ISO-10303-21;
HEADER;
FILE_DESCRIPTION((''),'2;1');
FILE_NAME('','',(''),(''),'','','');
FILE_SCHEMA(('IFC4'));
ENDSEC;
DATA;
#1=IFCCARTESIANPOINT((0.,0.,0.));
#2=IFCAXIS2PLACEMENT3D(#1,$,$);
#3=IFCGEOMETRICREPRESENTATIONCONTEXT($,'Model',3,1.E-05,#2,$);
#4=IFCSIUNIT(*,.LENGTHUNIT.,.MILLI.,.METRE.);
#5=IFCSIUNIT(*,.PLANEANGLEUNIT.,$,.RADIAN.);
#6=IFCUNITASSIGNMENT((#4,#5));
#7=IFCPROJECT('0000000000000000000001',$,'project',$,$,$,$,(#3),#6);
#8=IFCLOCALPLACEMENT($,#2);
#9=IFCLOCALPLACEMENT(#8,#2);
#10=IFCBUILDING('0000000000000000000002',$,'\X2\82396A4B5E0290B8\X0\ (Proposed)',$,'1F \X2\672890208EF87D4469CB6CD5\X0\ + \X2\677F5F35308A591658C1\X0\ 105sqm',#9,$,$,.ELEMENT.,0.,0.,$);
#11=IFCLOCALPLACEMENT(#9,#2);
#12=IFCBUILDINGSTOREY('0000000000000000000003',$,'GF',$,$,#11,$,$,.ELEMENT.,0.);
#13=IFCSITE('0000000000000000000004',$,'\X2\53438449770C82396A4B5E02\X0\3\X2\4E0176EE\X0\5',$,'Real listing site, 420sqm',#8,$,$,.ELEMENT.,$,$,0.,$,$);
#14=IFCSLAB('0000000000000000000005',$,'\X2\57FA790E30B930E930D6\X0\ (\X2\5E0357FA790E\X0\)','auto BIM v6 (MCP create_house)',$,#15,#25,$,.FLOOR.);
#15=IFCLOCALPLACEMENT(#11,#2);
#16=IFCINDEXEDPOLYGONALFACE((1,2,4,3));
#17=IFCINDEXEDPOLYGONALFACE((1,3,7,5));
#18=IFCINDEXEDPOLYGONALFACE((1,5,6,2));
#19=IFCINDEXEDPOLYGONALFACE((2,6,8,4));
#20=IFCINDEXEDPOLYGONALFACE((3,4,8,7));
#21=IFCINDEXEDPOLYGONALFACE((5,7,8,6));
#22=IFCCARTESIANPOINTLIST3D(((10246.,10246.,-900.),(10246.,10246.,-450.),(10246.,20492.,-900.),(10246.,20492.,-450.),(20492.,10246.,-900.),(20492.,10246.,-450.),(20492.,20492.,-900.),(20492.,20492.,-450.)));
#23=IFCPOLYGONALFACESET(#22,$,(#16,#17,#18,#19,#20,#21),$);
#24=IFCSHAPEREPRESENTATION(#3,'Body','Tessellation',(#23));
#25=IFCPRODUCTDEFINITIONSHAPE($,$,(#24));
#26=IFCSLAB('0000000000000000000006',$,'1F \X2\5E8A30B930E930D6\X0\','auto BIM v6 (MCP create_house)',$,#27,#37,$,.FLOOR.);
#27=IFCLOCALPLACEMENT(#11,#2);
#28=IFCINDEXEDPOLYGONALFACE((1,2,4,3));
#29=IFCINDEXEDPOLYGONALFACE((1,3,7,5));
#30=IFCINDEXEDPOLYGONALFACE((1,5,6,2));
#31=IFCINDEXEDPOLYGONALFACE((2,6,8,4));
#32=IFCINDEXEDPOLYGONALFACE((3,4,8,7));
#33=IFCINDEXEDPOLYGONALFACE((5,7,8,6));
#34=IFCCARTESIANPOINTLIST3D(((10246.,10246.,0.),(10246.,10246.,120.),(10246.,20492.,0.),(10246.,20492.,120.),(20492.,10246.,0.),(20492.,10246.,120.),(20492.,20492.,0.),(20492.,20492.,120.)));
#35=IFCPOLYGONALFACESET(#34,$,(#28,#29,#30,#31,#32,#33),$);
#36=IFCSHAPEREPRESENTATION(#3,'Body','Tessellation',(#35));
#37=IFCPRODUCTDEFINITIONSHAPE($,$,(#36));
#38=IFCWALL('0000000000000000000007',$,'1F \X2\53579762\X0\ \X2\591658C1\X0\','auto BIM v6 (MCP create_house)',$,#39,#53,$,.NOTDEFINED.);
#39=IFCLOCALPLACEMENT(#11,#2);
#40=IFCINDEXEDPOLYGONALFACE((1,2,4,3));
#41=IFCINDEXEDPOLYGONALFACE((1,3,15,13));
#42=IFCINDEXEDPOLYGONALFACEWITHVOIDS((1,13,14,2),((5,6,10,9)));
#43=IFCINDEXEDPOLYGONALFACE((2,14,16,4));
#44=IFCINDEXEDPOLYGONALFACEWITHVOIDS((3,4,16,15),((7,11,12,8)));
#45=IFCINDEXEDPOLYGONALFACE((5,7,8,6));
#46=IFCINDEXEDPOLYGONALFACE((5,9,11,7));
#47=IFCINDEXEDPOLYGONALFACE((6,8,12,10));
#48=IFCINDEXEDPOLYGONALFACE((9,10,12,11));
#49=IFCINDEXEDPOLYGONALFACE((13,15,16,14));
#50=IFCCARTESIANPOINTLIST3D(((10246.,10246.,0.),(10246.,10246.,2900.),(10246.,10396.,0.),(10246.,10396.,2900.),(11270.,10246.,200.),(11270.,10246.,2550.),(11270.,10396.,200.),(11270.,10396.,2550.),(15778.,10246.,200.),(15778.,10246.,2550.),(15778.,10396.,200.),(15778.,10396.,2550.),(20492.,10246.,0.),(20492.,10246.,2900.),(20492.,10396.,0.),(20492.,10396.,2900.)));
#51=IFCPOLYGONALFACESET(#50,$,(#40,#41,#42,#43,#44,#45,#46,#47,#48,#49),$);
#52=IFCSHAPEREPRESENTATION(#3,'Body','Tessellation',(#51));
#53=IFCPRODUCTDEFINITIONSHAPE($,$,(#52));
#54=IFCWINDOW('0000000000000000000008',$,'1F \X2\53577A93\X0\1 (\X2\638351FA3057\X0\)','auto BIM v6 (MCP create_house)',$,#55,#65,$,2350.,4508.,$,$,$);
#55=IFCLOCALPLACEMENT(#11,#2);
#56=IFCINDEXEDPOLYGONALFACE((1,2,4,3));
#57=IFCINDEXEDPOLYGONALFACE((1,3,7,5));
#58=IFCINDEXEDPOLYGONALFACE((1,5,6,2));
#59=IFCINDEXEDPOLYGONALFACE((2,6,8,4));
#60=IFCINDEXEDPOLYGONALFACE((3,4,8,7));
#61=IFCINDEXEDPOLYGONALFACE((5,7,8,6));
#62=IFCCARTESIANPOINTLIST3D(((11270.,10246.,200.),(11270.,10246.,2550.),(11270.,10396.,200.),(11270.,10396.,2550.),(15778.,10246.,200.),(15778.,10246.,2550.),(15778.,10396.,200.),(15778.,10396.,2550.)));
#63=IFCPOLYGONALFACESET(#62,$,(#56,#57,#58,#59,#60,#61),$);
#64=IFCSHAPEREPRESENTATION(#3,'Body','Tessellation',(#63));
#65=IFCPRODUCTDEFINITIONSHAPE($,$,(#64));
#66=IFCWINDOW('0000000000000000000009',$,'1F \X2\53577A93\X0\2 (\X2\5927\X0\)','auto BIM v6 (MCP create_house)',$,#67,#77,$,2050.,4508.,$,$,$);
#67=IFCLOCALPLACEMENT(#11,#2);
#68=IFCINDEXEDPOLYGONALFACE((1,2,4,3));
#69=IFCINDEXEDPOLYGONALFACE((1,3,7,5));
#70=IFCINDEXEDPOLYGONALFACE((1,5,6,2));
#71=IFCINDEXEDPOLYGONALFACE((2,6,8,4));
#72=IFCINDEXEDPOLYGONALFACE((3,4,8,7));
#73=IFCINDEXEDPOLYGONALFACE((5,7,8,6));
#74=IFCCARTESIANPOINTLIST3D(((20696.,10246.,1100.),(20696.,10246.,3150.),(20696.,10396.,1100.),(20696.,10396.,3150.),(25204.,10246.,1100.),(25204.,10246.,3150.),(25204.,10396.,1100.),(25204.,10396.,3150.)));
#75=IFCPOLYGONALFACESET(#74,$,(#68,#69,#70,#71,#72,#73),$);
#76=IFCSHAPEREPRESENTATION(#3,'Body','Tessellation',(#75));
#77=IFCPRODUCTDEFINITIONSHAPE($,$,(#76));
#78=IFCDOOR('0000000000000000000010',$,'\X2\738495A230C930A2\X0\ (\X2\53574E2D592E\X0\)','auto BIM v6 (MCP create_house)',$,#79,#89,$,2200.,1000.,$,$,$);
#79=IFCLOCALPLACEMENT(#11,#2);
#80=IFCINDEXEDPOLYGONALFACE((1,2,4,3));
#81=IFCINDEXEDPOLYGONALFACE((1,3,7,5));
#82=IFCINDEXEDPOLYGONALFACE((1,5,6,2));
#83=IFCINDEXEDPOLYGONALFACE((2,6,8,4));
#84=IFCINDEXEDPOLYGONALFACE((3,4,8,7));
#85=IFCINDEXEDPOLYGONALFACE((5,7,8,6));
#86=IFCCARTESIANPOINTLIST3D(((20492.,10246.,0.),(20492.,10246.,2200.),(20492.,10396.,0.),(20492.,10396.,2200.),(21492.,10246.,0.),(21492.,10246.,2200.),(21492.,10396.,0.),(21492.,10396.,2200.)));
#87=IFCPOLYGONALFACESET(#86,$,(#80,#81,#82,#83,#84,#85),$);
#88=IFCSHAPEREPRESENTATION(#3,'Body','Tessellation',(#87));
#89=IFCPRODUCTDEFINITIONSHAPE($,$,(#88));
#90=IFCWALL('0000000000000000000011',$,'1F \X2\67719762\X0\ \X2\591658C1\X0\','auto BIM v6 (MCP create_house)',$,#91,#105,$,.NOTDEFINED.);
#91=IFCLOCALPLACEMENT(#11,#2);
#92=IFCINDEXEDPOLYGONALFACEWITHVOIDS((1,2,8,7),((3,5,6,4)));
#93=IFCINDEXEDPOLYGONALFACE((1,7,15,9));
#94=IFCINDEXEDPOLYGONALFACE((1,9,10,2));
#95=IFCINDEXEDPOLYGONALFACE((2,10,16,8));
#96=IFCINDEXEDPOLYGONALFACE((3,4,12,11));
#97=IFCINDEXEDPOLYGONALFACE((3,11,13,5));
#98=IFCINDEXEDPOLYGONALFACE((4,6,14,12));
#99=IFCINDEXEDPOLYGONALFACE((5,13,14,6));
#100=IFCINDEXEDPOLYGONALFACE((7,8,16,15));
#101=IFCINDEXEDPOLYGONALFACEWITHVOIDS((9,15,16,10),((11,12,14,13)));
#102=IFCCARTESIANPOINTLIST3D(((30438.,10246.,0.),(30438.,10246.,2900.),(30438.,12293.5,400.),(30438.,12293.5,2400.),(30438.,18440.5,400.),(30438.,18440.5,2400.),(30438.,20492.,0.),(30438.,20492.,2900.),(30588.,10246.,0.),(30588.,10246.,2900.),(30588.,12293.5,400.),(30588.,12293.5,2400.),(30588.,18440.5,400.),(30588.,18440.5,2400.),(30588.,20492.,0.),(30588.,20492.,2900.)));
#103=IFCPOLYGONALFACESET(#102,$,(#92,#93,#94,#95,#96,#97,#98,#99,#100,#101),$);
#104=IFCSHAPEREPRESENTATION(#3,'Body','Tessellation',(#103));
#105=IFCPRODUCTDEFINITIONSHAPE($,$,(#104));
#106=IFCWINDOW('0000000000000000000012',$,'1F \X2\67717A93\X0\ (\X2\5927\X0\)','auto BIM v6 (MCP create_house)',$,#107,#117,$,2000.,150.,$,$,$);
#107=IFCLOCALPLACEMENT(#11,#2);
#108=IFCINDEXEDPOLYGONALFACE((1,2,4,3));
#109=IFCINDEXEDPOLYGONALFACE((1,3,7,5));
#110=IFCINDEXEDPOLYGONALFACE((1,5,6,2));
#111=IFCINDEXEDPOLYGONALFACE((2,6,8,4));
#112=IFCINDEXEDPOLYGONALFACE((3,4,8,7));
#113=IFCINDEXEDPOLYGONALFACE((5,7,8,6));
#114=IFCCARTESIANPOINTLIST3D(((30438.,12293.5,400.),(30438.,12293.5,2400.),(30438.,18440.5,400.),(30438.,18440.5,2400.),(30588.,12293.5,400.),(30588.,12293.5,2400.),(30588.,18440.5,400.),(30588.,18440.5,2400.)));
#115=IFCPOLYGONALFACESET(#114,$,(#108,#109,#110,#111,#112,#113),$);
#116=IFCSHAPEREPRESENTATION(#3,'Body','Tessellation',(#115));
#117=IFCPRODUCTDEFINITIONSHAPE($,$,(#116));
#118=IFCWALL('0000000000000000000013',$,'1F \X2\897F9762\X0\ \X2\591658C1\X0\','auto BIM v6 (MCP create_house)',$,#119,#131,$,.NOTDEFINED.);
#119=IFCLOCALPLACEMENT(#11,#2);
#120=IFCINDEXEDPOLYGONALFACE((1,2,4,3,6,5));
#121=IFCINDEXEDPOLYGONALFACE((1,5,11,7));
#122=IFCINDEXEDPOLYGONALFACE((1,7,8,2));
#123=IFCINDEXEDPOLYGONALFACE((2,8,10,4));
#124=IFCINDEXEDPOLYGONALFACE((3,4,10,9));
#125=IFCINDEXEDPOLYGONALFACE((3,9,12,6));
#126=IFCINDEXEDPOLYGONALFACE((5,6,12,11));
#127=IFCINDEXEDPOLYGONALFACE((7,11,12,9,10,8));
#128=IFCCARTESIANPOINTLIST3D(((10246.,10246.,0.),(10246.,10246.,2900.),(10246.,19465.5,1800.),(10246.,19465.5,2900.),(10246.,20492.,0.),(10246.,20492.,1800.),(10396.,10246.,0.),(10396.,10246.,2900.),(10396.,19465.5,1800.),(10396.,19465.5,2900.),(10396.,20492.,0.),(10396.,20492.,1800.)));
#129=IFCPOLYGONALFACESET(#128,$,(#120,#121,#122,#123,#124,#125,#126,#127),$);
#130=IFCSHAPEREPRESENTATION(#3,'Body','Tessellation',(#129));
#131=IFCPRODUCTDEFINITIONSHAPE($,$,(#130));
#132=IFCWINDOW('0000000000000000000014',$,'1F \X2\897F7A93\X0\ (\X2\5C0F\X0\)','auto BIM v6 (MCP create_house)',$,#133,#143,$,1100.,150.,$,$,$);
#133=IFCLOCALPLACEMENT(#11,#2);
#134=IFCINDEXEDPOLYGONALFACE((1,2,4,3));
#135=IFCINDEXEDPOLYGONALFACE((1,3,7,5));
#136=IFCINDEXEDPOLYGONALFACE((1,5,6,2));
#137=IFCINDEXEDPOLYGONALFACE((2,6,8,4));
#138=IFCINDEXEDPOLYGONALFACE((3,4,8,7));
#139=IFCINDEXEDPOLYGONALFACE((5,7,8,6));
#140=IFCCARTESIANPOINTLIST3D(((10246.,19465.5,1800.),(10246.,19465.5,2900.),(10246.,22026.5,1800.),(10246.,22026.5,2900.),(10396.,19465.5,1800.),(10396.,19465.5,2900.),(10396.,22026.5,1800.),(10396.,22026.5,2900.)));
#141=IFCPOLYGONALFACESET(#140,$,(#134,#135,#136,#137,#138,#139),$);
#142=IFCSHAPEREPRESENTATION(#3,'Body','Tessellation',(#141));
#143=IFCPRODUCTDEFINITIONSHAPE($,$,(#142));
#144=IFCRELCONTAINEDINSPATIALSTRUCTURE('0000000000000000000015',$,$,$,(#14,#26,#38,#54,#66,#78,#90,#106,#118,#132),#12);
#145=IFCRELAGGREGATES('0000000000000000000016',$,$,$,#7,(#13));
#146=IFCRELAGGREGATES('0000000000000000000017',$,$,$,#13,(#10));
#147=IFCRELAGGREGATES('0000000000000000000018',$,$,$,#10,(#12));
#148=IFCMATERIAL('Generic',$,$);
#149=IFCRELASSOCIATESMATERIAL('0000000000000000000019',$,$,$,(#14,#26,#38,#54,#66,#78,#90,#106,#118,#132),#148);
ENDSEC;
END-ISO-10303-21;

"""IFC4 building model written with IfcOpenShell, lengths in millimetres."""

from ifc_helpers import new_model, si_unit, frame, frame_2d, origin, place, context, project, spatial, rectangle, extrude, material, element, fill, save


model = new_model("IFC4")

# Units and contexts
model_context = context("Model", 3, precision=1e-05, world=origin())
ifc_project = project(units=[si_unit("LENGTHUNIT", "METRE", prefix="MILLI"), si_unit("PLANEANGLEUNIT", "RADIAN")], contexts=[model_context])

# Site, building, storey
site_placement = place(None, origin())
site = spatial("IfcSite", under=ifc_project, at=site_placement, Name="千葉県船橋市3丁目5", ObjectType="Real listing site, 420sqm", CompositionType="ELEMENT", RefElevation=0.0)
building_placement = place(site_placement, origin())
building = spatial("IfcBuilding", under=site, at=building_placement, Name="船橋市邸 (Proposed)", ObjectType="1F 木造軸組構法 + 板張り外壁 105sqm", CompositionType="ELEMENT", ElevationOfRefHeight=0.0, ElevationOfTerrain=0.0)
storey_placement = place(building_placement, origin())
storey = spatial("IfcBuildingStorey", under=building, at=storey_placement, Name="GF", CompositionType="ELEMENT", Elevation=0.0)

# Slabs
ifc_material = material(Name="Generic")
slab_1_placement = place(storey_placement, frame((5123.0, 5123.0, -450.0)))
element("IfcSlab", 1, at=slab_1_placement, inside=storey, material=ifc_material, Name="基礎スラブ (布基礎)", Description="auto BIM v6 (MCP create_house)", PredefinedType="FLOOR", context=model_context, shape_type="SweptSolid", body=[
    extrude(rectangle(XDim=10246.0, YDim=10246.0, at=frame_2d((5123.0, 5123.0))), frame((5123.0, 5123.0, -450.0)), (0.0, 0.0, 1.0), 450.0),
])
slab_2_placement = place(storey_placement, frame((5123.0, 5123.0, 0.0)))
element("IfcSlab", 2, at=slab_2_placement, inside=storey, material=ifc_material, Name="1F 床スラブ", Description="auto BIM v6 (MCP create_house)", PredefinedType="FLOOR", context=model_context, shape_type="SweptSolid", body=[
    extrude(rectangle(XDim=10246.0, YDim=10246.0, at=frame_2d((5123.0, 5123.0))), frame((5123.0, 5123.0, 0.0)), (0.0, 0.0, 1.0), 120.0),
])

# Wall, openings, windows, door
wall_1_placement = place(storey_placement, frame((5123.0, 5123.0, 0.0)))
wall_1 = element("IfcWall", 3, at=wall_1_placement, inside=storey, material=ifc_material, Name="1F 南面 外壁", Description="auto BIM v6 (MCP create_house)", PredefinedType="NOTDEFINED", context=model_context, shape_type="SweptSolid", body=[
    extrude(rectangle(XDim=10246.0, YDim=150.0, at=frame_2d((5123.0, 75.0))), frame((5123.0, 5123.0, 0.0)), (0.0, 0.0, 1.0), 2900.0),
])
opening_1_placement = place(storey_placement, frame((5635.0, 5123.0, 100.0)))
opening_1 = element("IfcOpeningElement", 4, at=opening_1_placement, cuts=wall_1, PredefinedType="NOTDEFINED", context=model_context, shape_type="SweptSolid", body=[
    extrude(rectangle(XDim=4508.0, YDim=150.0, at=frame_2d((2254.0, 75.0))), frame((5635.0, 5123.0, 100.0)), (0.0, 0.0, 1.0), 2350.0),
])
opening_2_placement = place(storey_placement, frame((10348.0, 5123.0, 550.0)))
opening_2 = element("IfcOpeningElement", 5, at=opening_2_placement, cuts=wall_1, PredefinedType="NOTDEFINED", context=model_context, shape_type="SweptSolid", body=[
    extrude(rectangle(XDim=4508.0, YDim=150.0, at=frame_2d((2254.0, 75.0))), frame((10348.0, 5123.0, 550.0)), (0.0, 0.0, 1.0), 2050.0),
])
opening_3_placement = place(storey_placement, frame((10246.0, 5123.0, 0.0)))
opening_3 = element("IfcOpeningElement", 6, at=opening_3_placement, cuts=wall_1, PredefinedType="NOTDEFINED", context=model_context, shape_type="SweptSolid", body=[
    extrude(rectangle(XDim=1000.0, YDim=150.0, at=frame_2d((500.0, 75.0))), frame((10246.0, 5123.0, 0.0)), (0.0, 0.0, 1.0), 2200.0),
])
window_1_placement = place(storey_placement, frame((5635.0, 5123.0, 100.0)))
window_1 = element("IfcWindow", 7, at=window_1_placement, inside=storey, material=ifc_material, Name="1F 南窓1 (掃出し)", Description="auto BIM v6 (MCP create_house)", OverallHeight=2350.0, OverallWidth=4508.0, context=model_context, shape_type="SweptSolid", body=[
    extrude(rectangle(XDim=4508.0, YDim=150.0, at=frame_2d((2254.0, 75.0))), frame((5635.0, 5123.0, 100.0)), (0.0, 0.0, 1.0), 2350.0),
])
fill(opening_1, window_1)
window_2_placement = place(storey_placement, frame((10348.0, 5123.0, 550.0)))
window_2 = element("IfcWindow", 8, at=window_2_placement, inside=storey, material=ifc_material, Name="1F 南窓2 (大)", Description="auto BIM v6 (MCP create_house)", OverallHeight=2050.0, OverallWidth=4508.0, context=model_context, shape_type="SweptSolid", body=[
    extrude(rectangle(XDim=4508.0, YDim=150.0, at=frame_2d((2254.0, 75.0))), frame((10348.0, 5123.0, 550.0)), (0.0, 0.0, 1.0), 2050.0),
])
fill(opening_2, window_2)
door_placement = place(storey_placement, frame((10246.0, 5123.0, 0.0)))
door = element("IfcDoor", 9, at=door_placement, inside=storey, material=ifc_material, Name="玄関ドア (南中央)", Description="auto BIM v6 (MCP create_house)", OverallHeight=2200.0, OverallWidth=1000.0, context=model_context, shape_type="SweptSolid", body=[
    extrude(rectangle(XDim=1000.0, YDim=150.0, at=frame_2d((500.0, 75.0))), frame((10246.0, 5123.0, 0.0)), (0.0, 0.0, 1.0), 2200.0),
])
fill(opening_3, door)

# Walls, openings, windows
wall_2_placement = place(storey_placement, frame((15219.0, 5123.0, 0.0)))
wall_2 = element("IfcWall", 10, at=wall_2_placement, inside=storey, material=ifc_material, Name="1F 東面 外壁", Description="auto BIM v6 (MCP create_house)", PredefinedType="NOTDEFINED", context=model_context, shape_type="SweptSolid", body=[
    extrude(rectangle(XDim=150.0, YDim=10246.0, at=frame_2d((75.0, 5123.0))), frame((15219.0, 5123.0, 0.0)), (0.0, 0.0, 1.0), 2900.0),
])
opening_4_placement = place(storey_placement, frame((15219.0, 6147.0, 200.0)))
opening_4 = element("IfcOpeningElement", 11, at=opening_4_placement, cuts=wall_2, PredefinedType="NOTDEFINED", context=model_context, shape_type="SweptSolid", body=[
    extrude(rectangle(XDim=150.0, YDim=6147.0, at=frame_2d((75.0, 3073.0))), frame((15219.0, 6147.0, 200.0)), (0.0, 0.0, 1.0), 2000.0),
])
window_3_placement = place(storey_placement, frame((15219.0, 6147.0, 200.0)))
window_3 = element("IfcWindow", 12, at=window_3_placement, inside=storey, material=ifc_material, Name="1F 東窓 (大)", Description="auto BIM v6 (MCP create_house)", OverallHeight=2000.0, OverallWidth=150.0, context=model_context, shape_type="SweptSolid", body=[
    extrude(rectangle(XDim=150.0, YDim=6147.0, at=frame_2d((75.0, 3073.0))), frame((15219.0, 6147.0, 200.0)), (0.0, 0.0, 1.0), 2000.0),
])
fill(opening_4, window_3)
wall_3_placement = place(storey_placement, frame((5123.0, 5123.0, 0.0)))
wall_3 = element("IfcWall", 13, at=wall_3_placement, inside=storey, material=ifc_material, Name="1F 西面 外壁", Description="auto BIM v6 (MCP create_house)", PredefinedType="NOTDEFINED", context=model_context, shape_type="SweptSolid", body=[
    extrude(rectangle(XDim=150.0, YDim=10246.0, at=frame_2d((75.0, 5123.0))), frame((5123.0, 5123.0, 0.0)), (0.0, 0.0, 1.0), 2900.0),
])
opening_5_placement = place(storey_placement, frame((5123.0, 9733.0, 900.0)))
opening_5 = element("IfcOpeningElement", 14, at=opening_5_placement, cuts=wall_3, PredefinedType="NOTDEFINED", context=model_context, shape_type="SweptSolid", body=[
    extrude(rectangle(XDim=150.0, YDim=2561.0, at=frame_2d((75.0, 1280.0))), frame((5123.0, 9733.0, 900.0)), (0.0, 0.0, 1.0), 1100.0),
])
window_4_placement = place(storey_placement, frame((5123.0, 9733.0, 900.0)))
window_4 = element("IfcWindow", 15, at=window_4_placement, inside=storey, material=ifc_material, Name="1F 西窓 (小)", Description="auto BIM v6 (MCP create_house)", OverallHeight=1100.0, OverallWidth=150.0, context=model_context, shape_type="SweptSolid", body=[
    extrude(rectangle(XDim=150.0, YDim=2561.0, at=frame_2d((75.0, 1280.0))), frame((5123.0, 9733.0, 900.0)), (0.0, 0.0, 1.0), 1100.0),
])
fill(opening_5, window_4)

save(model, "model.ifc")
